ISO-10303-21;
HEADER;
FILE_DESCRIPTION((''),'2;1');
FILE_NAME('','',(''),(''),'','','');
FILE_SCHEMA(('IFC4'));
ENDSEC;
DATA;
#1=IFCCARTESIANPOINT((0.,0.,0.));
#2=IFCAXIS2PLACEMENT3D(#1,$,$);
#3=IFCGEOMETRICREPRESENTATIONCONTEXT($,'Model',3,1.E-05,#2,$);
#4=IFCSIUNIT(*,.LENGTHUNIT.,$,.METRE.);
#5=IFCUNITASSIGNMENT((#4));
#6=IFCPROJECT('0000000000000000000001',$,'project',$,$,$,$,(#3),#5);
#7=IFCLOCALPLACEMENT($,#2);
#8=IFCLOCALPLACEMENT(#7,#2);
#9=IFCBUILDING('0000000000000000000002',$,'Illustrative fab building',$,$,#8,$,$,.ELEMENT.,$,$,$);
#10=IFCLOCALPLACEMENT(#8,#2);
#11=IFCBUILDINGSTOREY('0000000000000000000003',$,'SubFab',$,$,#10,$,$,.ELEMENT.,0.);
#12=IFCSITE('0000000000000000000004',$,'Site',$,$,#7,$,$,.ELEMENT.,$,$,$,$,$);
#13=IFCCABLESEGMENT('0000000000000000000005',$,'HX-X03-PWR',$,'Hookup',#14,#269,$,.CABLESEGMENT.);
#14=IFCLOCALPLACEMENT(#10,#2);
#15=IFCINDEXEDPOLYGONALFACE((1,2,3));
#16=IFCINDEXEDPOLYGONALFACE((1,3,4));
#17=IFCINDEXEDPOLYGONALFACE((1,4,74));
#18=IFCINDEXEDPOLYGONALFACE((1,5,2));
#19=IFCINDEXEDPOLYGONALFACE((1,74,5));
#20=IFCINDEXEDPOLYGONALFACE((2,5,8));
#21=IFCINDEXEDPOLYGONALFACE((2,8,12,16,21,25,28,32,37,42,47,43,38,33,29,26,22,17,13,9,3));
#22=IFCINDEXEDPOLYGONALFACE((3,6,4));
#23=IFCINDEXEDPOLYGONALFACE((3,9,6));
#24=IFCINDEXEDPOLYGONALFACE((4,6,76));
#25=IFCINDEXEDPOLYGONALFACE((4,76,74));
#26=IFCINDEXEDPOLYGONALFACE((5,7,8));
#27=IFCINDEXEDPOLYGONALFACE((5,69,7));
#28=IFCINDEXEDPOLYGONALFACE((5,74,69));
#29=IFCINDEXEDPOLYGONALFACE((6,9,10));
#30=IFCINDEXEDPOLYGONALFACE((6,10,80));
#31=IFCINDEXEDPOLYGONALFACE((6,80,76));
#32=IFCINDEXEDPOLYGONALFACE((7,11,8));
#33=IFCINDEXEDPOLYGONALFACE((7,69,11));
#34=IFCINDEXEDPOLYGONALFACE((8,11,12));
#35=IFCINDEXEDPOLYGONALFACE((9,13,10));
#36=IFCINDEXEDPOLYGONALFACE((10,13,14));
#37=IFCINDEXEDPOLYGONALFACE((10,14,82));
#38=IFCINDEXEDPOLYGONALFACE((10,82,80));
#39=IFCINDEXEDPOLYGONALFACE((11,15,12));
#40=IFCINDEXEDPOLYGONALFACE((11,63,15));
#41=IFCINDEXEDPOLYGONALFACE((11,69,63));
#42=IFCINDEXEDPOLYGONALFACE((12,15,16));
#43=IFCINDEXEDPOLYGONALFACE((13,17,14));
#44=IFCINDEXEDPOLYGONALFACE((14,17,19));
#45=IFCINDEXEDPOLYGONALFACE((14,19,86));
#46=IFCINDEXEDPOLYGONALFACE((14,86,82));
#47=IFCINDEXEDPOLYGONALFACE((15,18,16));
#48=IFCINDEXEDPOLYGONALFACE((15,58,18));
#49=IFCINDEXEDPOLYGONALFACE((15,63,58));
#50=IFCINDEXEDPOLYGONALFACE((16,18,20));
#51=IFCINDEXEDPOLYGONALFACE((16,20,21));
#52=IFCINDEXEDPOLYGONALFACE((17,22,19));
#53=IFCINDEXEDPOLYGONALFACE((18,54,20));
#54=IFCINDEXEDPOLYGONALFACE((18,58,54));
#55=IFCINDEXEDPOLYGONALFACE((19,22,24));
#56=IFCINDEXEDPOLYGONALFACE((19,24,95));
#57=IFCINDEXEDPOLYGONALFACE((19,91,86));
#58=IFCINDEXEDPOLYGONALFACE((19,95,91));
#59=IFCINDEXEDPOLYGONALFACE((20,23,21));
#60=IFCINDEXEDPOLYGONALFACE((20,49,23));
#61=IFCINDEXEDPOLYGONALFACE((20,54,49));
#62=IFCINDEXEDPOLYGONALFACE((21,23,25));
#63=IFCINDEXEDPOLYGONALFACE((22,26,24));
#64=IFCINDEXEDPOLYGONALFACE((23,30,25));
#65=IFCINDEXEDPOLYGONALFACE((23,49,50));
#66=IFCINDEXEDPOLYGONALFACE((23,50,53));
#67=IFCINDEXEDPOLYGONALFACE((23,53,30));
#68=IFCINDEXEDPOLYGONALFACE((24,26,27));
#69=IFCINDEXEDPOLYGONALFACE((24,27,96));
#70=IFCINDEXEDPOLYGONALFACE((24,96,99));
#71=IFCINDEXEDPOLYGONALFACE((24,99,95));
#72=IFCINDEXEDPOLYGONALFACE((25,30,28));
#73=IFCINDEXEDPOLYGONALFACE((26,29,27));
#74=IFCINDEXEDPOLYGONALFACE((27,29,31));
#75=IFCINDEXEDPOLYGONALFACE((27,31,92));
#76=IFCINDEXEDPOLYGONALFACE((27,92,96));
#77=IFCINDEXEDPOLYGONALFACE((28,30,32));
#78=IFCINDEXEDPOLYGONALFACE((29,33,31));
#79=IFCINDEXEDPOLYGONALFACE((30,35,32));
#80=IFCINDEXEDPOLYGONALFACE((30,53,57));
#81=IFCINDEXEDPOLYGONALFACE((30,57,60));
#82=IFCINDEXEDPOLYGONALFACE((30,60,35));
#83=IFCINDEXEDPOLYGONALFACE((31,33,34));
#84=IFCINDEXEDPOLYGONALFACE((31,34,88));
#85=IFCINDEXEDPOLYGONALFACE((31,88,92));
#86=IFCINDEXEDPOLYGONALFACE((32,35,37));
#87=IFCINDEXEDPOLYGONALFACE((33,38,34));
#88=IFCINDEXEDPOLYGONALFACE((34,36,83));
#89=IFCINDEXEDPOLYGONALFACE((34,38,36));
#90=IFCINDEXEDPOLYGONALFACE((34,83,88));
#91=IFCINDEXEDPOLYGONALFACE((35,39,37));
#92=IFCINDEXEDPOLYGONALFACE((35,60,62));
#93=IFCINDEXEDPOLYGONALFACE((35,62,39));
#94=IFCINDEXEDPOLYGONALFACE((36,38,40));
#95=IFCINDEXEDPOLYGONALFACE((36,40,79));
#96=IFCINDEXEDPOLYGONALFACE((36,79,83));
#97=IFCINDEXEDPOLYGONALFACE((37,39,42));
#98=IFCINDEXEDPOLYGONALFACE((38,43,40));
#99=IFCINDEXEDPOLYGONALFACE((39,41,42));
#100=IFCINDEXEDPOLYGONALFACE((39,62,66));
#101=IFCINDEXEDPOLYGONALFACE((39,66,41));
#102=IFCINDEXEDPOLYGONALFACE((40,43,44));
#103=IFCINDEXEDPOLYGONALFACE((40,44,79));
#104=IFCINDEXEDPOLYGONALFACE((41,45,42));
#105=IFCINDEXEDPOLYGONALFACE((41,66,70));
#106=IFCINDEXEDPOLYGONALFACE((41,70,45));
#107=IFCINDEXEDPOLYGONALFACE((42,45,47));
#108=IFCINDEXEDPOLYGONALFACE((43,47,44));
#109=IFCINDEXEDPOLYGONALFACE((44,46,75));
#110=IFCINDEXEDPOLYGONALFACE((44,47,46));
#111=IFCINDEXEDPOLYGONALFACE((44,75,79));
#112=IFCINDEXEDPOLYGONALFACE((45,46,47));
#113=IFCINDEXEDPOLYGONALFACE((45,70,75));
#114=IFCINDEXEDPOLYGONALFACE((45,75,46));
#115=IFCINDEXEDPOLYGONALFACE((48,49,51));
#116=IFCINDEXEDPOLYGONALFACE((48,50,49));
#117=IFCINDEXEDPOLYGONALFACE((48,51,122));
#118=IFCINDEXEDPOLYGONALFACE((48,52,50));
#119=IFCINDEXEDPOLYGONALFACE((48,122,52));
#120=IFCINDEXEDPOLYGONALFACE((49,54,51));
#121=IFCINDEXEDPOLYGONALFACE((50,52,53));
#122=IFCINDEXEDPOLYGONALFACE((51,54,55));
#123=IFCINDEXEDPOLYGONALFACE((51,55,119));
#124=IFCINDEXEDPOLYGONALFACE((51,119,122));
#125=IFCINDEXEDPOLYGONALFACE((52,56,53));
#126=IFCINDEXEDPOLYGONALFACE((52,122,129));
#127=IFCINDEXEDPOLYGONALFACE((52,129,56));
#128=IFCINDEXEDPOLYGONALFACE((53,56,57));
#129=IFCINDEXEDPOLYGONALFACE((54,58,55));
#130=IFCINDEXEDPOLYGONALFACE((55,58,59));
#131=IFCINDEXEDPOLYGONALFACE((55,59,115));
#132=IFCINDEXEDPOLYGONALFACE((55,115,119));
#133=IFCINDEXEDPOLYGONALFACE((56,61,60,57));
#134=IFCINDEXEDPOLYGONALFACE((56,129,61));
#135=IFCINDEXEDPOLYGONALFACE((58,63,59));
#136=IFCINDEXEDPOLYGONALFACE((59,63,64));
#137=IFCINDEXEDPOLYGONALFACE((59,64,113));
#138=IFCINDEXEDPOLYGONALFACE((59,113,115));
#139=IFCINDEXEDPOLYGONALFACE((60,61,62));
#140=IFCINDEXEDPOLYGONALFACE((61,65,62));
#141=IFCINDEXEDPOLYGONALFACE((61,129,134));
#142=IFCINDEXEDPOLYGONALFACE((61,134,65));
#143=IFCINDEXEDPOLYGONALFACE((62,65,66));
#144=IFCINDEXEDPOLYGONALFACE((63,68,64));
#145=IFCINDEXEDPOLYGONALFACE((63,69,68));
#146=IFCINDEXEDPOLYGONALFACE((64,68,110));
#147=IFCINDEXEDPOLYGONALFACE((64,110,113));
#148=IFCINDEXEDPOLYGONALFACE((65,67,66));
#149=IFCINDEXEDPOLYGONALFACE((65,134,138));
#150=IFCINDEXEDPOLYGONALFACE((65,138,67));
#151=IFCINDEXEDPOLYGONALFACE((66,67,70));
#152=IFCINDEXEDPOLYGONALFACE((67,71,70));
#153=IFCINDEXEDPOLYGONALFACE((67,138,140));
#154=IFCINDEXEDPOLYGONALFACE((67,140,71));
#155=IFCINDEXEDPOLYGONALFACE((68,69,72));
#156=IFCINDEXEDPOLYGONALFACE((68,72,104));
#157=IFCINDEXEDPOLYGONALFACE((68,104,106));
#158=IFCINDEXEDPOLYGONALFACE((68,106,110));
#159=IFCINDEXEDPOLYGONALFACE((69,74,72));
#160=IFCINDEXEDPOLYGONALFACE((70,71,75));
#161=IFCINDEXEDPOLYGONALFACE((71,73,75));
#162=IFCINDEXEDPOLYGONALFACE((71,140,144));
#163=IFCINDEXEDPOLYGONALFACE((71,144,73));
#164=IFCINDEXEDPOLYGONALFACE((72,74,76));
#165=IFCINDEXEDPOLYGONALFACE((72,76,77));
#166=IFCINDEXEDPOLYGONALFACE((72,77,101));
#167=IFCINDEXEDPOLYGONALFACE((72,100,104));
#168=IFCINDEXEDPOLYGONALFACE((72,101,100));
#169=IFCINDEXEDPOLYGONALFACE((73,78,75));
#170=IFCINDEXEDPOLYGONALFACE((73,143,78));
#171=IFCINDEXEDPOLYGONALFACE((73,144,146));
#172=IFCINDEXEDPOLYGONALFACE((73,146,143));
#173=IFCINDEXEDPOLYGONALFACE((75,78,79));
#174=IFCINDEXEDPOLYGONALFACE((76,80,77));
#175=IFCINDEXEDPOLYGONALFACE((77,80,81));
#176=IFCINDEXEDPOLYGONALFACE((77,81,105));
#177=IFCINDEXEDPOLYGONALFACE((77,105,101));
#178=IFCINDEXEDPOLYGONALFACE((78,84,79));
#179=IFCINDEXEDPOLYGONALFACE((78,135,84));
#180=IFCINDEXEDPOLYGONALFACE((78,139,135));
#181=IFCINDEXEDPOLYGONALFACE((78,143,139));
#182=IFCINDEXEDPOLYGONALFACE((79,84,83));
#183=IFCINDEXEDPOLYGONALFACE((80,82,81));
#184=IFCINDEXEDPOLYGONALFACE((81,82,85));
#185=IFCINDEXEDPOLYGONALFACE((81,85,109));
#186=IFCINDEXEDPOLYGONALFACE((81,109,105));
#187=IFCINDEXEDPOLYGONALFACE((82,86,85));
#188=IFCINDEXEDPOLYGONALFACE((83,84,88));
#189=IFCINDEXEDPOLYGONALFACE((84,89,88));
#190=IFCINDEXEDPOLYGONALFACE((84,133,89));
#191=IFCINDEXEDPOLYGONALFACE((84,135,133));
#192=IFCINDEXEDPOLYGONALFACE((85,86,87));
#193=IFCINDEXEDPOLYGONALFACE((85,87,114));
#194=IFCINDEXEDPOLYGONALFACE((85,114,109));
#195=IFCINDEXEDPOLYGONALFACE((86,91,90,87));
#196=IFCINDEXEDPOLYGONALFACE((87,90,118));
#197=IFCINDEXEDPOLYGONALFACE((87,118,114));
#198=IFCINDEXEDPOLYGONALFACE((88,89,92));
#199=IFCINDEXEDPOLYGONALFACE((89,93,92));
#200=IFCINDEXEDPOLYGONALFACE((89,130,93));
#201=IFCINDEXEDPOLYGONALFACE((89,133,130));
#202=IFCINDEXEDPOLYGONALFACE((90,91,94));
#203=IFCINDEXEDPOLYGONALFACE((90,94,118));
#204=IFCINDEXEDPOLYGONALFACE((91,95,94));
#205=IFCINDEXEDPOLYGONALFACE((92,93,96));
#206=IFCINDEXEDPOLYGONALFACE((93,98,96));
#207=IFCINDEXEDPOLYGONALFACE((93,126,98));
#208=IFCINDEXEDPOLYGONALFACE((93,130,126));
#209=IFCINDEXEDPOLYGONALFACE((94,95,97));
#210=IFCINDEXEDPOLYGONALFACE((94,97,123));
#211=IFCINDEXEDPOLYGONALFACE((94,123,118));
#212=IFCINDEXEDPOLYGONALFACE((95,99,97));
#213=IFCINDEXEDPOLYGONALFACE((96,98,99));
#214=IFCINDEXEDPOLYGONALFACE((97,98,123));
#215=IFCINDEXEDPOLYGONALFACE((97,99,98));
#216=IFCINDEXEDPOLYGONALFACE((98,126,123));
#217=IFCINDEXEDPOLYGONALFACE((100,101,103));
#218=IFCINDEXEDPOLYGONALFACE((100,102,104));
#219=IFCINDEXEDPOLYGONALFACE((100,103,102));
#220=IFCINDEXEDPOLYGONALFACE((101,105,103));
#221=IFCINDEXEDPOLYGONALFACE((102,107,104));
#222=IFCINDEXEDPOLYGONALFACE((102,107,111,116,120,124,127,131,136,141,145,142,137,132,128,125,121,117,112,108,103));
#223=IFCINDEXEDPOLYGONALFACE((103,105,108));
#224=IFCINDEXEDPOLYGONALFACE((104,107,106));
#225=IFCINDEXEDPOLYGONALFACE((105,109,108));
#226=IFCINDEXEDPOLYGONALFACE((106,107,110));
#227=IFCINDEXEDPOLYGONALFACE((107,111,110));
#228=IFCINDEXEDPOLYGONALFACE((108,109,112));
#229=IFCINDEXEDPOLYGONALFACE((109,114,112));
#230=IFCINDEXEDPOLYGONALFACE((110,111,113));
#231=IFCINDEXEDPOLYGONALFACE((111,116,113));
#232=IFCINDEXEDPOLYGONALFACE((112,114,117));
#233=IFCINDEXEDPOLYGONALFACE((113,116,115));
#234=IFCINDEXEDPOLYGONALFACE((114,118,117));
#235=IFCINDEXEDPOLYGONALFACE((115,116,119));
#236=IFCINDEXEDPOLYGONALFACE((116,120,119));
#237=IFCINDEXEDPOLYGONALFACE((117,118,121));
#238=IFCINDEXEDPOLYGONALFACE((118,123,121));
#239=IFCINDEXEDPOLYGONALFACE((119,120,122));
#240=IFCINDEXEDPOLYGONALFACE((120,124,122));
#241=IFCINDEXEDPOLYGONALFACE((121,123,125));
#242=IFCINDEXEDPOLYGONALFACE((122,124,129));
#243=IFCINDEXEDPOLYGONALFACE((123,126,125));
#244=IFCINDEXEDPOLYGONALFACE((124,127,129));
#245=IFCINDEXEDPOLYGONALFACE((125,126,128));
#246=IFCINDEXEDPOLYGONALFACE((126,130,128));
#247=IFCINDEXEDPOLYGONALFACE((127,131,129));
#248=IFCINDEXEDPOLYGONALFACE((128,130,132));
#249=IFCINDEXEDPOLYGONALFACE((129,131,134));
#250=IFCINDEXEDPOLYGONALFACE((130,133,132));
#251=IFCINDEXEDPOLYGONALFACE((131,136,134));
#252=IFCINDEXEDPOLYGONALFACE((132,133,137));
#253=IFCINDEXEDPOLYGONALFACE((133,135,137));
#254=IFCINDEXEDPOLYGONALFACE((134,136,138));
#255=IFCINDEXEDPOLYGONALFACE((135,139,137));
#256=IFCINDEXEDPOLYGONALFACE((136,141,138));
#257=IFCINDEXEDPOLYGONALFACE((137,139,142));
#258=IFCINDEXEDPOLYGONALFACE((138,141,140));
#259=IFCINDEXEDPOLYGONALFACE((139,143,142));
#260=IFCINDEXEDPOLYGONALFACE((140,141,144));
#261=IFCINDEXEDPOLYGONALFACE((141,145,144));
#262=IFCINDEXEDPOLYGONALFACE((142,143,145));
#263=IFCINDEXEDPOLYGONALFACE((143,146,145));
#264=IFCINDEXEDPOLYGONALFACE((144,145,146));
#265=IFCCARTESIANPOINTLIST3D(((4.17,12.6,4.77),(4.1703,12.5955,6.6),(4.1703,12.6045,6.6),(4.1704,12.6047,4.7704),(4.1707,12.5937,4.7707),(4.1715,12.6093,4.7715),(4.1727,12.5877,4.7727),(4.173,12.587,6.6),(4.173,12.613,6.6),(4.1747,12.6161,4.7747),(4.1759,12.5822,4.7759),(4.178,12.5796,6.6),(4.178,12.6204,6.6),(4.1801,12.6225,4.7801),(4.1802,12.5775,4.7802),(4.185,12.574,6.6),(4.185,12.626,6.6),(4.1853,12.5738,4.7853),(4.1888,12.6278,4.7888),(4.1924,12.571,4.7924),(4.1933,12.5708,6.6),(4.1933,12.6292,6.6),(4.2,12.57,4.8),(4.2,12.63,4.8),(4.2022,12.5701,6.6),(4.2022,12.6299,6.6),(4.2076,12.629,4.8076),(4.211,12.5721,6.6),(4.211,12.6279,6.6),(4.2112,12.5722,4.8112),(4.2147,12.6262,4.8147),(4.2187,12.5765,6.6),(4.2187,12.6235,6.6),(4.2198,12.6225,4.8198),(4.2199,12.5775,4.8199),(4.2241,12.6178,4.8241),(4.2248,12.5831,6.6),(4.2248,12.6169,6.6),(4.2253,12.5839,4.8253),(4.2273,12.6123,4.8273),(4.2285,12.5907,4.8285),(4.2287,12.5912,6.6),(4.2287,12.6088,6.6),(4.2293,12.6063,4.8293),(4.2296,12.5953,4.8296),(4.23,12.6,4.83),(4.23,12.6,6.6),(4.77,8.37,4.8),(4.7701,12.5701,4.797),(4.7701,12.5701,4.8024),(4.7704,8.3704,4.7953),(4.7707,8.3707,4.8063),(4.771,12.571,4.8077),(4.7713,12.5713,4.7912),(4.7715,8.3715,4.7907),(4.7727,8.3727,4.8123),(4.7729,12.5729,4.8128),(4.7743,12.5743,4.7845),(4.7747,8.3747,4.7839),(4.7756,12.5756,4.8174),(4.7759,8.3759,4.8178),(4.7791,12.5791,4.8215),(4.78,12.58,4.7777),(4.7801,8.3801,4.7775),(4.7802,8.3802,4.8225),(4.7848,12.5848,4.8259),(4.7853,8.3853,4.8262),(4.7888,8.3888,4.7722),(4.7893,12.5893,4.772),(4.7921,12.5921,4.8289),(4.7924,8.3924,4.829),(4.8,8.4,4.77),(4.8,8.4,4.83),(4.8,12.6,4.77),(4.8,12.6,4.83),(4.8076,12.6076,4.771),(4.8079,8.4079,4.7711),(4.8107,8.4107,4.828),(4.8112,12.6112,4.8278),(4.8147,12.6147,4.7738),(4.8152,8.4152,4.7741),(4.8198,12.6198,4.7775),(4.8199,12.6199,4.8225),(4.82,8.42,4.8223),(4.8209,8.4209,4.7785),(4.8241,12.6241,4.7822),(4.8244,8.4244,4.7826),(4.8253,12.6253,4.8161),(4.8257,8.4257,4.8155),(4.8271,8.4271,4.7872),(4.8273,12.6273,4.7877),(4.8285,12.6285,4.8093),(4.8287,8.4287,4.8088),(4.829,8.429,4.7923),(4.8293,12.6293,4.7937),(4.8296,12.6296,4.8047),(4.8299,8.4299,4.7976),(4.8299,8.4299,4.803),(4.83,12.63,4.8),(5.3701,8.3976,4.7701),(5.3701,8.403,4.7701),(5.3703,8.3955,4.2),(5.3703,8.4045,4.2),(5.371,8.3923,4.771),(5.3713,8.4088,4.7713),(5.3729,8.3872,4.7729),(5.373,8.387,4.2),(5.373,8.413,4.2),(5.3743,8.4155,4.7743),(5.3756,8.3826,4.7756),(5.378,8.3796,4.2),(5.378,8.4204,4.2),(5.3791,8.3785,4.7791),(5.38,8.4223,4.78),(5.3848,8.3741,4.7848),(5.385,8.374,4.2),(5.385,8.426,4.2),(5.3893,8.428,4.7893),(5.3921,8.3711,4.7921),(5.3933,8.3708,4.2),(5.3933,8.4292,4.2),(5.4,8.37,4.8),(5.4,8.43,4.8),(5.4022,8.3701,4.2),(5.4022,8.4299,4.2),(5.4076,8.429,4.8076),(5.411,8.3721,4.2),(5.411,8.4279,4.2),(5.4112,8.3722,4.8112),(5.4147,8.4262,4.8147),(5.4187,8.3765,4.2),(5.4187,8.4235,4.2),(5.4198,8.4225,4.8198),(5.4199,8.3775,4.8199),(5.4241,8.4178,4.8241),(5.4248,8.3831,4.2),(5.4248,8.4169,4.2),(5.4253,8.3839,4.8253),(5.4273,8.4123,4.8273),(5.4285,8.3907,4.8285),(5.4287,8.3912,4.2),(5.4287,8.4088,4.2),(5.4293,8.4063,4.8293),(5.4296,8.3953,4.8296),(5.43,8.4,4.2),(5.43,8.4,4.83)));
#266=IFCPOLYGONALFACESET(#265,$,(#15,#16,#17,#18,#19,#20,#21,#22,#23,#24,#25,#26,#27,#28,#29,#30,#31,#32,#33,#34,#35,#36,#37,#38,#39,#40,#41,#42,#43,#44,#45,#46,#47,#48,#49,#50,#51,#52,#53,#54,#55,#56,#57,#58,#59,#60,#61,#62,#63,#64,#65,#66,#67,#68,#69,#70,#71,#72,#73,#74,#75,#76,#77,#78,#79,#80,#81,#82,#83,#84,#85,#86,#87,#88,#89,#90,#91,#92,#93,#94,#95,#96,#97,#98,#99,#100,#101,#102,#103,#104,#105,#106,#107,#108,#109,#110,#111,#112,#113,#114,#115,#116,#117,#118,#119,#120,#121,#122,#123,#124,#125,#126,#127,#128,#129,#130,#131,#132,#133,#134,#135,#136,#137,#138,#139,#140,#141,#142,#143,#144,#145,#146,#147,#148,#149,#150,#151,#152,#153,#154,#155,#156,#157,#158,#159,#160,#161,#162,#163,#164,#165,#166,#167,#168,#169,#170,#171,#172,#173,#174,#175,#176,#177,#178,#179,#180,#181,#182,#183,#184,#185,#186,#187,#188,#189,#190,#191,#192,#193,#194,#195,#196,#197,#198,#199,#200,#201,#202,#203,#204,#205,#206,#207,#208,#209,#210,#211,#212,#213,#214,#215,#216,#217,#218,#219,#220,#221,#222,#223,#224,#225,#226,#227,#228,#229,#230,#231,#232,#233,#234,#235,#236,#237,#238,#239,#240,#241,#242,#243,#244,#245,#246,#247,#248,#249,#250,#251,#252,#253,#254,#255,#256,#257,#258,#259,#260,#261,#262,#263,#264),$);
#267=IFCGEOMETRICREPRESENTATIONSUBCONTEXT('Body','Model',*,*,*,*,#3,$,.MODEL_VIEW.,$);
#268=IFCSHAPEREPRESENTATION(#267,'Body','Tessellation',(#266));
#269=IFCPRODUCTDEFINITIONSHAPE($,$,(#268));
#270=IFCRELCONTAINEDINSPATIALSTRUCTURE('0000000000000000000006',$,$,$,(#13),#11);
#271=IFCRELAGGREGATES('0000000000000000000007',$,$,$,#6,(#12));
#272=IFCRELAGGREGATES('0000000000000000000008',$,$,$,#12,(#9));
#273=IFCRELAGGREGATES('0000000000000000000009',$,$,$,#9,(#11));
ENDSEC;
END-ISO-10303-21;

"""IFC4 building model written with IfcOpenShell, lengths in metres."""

from ifc_helpers import new_model, entity, si_unit, origin, place, context, subcontext, project, spatial, element, save


model = new_model("IFC4")

# Units and contexts
model_context = context("Model", 3, precision=1e-05, world=origin())
body_context = subcontext(model_context, "Body", "Model", "MODEL_VIEW")
ifc_project = project(units=[si_unit("LENGTHUNIT", "METRE")], contexts=[model_context])

# Site, building, storey
site_placement = place(None, origin())
site = spatial("IfcSite", under=ifc_project, at=site_placement, Name="Site", CompositionType="ELEMENT")
building_placement = place(site_placement, origin())
building = spatial("IfcBuilding", under=site, at=building_placement, Name="Illustrative fab building", CompositionType="ELEMENT")
storey_placement = place(building_placement, origin())
storey = spatial("IfcBuildingStorey", under=building, at=storey_placement, Name="SubFab", CompositionType="ELEMENT", Elevation=0.0)

# Cable segment
cable_segment_1_placement = place(storey_placement, origin())
element("IfcCableSegment", 1, at=cable_segment_1_placement, inside=storey, Name="HX-X03-PWR", ObjectType="Hookup", PredefinedType="CABLESEGMENT", context=body_context, shape_type="AdvancedSweptSolid", body=[
    entity("IfcSweptDiskSolid", entity("IfcPolyline", [entity("IfcCartesianPoint", [5.4, 8.4, 4.2]), entity("IfcCartesianPoint", [5.4, 8.4, 4.8]), entity("IfcCartesianPoint", [4.8, 8.4, 4.8]), entity("IfcCartesianPoint", [4.8, 12.6, 4.8]), entity("IfcCartesianPoint", [4.2, 12.6, 4.8]), entity("IfcCartesianPoint", [4.2, 12.6, 6.6])]), 0.03),
])

save(model, "model.ifc")
